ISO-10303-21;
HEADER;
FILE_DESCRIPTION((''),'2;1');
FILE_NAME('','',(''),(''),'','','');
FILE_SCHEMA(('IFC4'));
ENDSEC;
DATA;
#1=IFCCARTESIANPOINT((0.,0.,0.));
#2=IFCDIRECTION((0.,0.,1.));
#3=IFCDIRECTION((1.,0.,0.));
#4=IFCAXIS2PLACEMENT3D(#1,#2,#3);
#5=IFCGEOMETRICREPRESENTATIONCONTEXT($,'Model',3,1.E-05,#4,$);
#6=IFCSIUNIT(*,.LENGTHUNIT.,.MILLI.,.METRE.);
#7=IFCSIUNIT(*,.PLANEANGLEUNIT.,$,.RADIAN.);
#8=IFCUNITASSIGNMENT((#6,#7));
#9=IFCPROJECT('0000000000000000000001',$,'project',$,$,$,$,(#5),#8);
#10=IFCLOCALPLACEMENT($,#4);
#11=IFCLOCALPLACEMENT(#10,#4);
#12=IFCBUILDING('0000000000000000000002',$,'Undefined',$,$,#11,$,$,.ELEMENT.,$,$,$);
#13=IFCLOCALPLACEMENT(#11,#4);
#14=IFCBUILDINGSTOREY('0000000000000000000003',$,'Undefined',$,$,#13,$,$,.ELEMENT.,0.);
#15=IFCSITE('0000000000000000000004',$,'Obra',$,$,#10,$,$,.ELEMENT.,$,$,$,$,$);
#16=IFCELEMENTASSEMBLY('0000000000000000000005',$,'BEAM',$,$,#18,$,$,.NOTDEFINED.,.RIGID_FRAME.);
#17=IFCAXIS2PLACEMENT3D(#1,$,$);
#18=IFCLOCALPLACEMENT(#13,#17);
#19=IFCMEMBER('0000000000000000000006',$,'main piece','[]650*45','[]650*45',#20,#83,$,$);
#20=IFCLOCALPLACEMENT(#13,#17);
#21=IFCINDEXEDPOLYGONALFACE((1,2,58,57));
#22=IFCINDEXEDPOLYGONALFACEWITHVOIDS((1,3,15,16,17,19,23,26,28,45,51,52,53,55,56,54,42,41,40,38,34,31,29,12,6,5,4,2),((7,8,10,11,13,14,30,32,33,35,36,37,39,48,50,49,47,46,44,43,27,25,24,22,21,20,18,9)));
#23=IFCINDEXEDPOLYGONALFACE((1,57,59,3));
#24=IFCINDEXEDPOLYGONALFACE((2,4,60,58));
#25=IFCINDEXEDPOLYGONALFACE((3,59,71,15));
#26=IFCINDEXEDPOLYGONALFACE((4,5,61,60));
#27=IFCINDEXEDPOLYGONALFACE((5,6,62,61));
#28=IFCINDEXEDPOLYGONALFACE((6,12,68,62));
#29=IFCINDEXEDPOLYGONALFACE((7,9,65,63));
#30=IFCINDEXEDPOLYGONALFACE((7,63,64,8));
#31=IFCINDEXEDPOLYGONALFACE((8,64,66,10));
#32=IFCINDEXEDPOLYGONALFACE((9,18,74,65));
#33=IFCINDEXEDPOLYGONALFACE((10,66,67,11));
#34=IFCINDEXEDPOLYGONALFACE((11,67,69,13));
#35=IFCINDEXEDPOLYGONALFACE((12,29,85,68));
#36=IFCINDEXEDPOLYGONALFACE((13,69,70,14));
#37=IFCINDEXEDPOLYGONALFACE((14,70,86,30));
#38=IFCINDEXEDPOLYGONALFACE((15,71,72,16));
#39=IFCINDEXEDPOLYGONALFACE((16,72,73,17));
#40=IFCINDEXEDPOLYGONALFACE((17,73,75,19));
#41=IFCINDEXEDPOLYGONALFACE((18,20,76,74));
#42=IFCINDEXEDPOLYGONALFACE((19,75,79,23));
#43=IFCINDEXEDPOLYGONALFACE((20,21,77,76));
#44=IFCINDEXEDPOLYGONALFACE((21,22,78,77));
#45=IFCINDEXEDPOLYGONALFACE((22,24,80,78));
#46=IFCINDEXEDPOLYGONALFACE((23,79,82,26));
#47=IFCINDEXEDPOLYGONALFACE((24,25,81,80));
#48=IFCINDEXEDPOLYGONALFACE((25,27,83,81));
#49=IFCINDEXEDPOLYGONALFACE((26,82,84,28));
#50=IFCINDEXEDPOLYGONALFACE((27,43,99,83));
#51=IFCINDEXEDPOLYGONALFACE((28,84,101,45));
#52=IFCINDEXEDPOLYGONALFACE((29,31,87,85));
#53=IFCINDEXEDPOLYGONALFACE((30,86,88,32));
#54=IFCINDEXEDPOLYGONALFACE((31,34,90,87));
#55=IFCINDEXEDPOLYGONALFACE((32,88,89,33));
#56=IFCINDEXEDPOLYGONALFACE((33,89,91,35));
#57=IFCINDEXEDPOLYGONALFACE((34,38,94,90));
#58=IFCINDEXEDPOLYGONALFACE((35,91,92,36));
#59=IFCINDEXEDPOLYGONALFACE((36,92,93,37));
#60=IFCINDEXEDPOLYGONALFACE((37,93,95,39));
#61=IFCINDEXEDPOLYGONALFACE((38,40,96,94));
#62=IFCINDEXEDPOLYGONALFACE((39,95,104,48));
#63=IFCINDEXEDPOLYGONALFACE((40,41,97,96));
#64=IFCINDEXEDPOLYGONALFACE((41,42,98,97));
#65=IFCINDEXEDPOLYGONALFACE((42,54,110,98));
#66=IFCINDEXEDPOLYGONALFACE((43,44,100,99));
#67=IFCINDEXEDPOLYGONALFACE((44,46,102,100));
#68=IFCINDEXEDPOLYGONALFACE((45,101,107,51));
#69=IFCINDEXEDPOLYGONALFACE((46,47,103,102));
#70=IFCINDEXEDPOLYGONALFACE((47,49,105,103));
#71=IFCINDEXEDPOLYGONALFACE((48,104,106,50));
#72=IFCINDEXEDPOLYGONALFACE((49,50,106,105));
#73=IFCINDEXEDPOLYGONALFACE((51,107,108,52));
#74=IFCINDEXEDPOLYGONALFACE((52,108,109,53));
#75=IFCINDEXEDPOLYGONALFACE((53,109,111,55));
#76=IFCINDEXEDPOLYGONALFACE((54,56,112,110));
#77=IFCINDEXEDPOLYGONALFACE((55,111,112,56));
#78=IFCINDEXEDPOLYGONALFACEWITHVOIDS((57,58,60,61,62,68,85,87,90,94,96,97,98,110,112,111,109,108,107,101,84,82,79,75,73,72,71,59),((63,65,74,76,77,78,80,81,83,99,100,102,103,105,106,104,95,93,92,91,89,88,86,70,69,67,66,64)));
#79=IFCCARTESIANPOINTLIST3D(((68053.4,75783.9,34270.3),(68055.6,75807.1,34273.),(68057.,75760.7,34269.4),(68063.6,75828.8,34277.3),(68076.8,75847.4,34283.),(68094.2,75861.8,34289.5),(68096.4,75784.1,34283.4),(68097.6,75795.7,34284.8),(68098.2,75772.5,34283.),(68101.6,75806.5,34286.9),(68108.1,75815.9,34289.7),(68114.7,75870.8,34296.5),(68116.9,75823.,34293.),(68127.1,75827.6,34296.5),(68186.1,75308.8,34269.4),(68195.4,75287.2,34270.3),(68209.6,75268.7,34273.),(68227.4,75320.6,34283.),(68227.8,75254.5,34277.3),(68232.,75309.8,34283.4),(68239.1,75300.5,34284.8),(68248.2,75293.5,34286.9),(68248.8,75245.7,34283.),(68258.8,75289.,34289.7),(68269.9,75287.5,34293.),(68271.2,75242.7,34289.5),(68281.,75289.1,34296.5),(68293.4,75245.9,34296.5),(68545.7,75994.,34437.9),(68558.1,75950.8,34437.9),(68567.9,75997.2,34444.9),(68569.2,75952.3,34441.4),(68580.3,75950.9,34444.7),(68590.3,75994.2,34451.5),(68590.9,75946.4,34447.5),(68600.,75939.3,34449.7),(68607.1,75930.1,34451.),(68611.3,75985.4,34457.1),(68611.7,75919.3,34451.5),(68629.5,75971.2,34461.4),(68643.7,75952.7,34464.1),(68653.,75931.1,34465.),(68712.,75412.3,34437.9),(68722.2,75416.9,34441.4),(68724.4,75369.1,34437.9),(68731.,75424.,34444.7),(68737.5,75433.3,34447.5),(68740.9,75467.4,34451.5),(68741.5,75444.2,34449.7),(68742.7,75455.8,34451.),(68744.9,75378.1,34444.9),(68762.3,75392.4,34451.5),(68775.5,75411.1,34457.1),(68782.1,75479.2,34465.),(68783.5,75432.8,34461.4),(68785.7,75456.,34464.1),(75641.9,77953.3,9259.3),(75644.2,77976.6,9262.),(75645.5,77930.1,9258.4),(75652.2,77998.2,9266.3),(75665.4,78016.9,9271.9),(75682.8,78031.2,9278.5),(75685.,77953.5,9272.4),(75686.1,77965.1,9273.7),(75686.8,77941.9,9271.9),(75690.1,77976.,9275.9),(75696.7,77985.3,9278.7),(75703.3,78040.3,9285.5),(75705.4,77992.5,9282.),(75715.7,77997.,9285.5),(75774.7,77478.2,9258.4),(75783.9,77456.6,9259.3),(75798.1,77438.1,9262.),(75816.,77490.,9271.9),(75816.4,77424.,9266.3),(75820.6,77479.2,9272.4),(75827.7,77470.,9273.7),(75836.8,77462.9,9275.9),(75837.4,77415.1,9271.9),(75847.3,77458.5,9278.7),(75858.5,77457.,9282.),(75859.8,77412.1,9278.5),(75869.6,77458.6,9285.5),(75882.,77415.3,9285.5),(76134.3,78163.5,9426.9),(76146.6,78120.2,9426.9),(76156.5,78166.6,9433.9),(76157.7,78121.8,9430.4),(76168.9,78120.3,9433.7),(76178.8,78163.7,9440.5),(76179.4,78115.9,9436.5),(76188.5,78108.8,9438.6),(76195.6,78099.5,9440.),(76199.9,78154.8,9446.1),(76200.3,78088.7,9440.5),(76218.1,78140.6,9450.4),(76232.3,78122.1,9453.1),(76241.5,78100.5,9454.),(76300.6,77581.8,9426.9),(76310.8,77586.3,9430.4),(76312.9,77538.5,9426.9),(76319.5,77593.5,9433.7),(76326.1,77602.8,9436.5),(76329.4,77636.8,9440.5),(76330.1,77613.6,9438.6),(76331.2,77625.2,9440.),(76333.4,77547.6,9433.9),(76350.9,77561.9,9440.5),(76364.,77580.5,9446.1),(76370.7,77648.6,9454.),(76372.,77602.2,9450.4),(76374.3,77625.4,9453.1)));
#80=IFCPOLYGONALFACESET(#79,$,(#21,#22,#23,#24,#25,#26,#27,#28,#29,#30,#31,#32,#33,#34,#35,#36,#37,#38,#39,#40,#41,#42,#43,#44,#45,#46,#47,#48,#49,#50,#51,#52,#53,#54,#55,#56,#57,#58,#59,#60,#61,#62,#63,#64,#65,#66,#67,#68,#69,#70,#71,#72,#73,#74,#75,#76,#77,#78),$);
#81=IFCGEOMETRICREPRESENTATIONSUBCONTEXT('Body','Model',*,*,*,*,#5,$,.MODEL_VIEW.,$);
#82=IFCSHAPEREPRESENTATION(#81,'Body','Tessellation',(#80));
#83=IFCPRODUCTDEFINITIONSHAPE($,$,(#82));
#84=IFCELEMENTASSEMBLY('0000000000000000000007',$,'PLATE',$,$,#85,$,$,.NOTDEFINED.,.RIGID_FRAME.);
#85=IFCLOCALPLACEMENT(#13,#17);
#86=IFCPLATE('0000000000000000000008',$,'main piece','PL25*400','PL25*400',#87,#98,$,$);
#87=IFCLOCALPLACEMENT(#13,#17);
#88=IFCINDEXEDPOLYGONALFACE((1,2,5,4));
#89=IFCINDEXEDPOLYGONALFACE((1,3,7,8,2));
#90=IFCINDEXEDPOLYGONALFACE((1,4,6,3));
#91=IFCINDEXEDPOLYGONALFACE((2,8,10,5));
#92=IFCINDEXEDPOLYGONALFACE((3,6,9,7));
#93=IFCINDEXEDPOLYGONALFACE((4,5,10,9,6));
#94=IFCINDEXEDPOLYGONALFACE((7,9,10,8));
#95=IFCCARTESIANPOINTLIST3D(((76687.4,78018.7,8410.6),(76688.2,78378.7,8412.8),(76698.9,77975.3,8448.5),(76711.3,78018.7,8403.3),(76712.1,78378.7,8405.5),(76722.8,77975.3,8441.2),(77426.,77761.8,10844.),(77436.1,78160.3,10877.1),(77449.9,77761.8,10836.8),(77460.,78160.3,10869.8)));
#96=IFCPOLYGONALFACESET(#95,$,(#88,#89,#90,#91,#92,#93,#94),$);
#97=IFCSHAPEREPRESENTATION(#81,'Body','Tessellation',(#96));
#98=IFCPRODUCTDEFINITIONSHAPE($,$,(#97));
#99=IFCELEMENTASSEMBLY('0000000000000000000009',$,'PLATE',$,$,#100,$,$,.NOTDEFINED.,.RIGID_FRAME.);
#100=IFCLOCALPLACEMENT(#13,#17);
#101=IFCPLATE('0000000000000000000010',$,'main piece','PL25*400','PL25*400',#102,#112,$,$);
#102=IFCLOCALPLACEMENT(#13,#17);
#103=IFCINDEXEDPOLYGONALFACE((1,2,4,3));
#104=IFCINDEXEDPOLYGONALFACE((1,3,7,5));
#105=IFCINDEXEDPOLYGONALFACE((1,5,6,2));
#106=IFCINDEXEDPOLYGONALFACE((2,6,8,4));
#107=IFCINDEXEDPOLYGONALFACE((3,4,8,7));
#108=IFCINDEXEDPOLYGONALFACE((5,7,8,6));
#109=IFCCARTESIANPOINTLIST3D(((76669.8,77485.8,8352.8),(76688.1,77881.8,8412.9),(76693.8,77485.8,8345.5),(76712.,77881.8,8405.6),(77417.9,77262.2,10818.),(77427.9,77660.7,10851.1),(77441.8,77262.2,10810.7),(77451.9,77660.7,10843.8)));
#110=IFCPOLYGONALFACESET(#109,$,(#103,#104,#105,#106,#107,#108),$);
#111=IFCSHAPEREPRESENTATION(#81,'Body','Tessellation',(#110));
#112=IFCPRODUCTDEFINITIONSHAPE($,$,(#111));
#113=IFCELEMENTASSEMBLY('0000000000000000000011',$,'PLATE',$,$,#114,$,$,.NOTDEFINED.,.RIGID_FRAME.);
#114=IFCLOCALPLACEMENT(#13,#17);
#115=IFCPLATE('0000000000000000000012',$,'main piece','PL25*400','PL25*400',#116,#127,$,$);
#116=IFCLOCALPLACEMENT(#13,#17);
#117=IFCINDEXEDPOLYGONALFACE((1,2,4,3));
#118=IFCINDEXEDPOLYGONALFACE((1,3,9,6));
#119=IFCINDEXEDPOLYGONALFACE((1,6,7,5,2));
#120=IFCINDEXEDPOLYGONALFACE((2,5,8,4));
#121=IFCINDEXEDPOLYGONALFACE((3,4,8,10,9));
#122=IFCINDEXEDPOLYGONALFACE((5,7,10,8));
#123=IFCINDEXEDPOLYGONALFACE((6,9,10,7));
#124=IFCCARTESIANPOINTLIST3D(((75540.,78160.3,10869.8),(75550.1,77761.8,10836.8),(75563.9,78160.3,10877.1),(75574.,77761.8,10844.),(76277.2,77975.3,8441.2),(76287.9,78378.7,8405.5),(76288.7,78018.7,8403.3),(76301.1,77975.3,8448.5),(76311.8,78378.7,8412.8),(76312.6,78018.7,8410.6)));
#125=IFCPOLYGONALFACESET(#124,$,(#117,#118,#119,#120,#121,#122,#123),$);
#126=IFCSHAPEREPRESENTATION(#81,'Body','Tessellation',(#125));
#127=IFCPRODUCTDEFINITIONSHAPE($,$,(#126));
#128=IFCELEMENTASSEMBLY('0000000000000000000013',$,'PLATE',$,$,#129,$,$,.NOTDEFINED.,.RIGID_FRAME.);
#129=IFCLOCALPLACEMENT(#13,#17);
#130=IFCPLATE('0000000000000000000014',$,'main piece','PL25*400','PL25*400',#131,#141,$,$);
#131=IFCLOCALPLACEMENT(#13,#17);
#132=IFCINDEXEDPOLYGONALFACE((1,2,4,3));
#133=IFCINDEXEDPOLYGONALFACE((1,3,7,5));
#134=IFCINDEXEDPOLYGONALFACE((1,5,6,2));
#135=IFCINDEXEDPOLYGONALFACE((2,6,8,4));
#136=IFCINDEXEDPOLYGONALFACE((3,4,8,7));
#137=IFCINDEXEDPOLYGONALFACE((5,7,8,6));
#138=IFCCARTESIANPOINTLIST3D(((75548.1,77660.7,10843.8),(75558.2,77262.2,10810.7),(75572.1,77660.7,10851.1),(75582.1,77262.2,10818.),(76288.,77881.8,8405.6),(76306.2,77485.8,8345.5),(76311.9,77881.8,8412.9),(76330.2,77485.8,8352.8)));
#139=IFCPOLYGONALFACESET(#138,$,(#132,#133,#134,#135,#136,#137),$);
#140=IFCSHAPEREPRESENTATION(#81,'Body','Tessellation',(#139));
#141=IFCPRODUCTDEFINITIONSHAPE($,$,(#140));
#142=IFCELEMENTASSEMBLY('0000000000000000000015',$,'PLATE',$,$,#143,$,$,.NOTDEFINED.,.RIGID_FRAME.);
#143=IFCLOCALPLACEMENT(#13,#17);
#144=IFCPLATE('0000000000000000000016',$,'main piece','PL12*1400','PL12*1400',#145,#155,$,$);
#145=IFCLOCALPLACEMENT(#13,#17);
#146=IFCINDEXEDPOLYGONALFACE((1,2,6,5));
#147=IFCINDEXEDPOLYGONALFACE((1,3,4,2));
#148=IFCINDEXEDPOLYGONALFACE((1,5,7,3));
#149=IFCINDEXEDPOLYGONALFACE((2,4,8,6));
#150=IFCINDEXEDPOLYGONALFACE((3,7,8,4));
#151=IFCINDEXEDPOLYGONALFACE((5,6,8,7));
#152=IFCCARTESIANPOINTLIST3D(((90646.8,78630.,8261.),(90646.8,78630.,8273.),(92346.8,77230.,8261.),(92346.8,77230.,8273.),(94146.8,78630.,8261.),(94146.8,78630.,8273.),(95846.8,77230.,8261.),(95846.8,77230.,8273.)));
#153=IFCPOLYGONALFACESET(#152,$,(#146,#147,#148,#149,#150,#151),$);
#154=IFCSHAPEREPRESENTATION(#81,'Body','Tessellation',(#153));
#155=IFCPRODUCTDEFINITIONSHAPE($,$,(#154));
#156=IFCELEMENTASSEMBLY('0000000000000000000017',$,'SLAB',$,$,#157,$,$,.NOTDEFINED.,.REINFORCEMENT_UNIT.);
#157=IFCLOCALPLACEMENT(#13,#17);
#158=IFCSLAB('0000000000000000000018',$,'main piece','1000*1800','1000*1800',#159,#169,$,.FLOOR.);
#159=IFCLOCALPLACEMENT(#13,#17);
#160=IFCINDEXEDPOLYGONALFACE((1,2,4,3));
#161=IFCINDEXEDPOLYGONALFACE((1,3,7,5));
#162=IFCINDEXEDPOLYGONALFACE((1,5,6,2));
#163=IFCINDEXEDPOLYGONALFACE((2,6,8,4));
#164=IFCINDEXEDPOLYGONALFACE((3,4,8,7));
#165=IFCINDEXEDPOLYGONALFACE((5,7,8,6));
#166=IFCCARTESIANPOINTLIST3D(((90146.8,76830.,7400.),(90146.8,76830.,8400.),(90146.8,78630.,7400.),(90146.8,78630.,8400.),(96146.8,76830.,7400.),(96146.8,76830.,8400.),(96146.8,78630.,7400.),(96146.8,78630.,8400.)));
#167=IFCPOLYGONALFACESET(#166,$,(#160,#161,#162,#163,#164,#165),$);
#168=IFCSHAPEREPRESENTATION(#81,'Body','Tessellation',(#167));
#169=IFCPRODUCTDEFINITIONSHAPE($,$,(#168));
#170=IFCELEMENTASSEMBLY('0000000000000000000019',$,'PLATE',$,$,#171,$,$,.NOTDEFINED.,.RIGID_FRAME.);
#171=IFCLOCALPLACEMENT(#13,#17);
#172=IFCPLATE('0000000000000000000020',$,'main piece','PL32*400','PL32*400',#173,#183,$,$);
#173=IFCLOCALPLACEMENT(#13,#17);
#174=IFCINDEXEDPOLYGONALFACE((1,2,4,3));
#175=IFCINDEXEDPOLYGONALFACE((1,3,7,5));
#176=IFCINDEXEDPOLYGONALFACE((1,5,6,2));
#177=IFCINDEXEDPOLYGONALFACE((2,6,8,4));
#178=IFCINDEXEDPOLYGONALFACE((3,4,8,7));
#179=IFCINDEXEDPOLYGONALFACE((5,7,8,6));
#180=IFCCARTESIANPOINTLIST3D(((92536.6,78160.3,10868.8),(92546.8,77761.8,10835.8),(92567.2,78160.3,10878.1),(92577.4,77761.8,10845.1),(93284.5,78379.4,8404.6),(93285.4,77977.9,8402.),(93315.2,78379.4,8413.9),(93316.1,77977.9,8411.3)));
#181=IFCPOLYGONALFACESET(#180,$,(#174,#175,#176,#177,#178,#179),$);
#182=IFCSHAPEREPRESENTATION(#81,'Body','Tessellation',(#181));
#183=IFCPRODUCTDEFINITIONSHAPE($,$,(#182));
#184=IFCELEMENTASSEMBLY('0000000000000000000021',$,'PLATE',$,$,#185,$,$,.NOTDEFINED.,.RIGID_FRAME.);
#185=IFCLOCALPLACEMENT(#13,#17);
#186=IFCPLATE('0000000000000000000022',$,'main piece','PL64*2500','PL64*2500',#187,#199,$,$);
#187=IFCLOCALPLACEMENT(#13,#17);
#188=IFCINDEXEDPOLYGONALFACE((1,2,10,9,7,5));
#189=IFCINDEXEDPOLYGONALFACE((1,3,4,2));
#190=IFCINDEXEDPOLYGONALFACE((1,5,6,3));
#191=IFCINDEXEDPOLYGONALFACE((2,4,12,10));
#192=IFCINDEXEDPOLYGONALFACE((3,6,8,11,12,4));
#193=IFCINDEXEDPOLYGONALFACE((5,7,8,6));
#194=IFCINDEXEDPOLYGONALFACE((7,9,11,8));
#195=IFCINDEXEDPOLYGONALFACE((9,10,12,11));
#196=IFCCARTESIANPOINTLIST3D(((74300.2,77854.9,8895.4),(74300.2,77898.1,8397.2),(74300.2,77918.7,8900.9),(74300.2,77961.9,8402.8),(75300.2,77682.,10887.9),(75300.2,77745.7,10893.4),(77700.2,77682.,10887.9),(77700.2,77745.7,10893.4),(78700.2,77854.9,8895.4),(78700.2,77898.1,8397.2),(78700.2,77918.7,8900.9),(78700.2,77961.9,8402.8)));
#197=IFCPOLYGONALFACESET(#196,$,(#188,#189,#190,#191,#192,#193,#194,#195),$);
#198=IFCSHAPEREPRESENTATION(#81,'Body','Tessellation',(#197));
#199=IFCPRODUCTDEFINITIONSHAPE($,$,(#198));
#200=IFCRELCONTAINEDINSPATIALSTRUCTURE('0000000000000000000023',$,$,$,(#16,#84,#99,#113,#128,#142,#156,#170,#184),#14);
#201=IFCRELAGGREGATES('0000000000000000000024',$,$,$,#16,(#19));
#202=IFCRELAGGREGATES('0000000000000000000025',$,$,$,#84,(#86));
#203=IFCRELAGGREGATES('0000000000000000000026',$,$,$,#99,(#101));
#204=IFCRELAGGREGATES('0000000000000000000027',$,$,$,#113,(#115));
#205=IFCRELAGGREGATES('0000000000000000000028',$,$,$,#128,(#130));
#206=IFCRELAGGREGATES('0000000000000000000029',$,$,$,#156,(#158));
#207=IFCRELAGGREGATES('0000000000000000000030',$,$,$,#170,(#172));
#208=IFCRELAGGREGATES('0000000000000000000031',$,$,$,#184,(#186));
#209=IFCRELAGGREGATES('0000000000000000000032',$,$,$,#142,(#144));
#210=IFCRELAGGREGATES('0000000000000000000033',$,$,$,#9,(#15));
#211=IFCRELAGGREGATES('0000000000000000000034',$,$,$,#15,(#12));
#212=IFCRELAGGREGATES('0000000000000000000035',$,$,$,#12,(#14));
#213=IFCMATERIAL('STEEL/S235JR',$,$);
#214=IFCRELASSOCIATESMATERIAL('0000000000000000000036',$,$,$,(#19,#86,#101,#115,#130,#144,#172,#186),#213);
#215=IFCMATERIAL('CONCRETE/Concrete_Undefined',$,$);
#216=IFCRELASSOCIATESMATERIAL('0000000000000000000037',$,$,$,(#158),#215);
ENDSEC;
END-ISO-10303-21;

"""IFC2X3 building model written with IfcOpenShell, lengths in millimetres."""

from ifc_helpers import new_model, si_unit, frame, origin_with_axes, origin_2d_with_axis, place, context, subcontext, project, spatial, polyline, hollow_rectangle, outline, extrude, material, element, aggregate, save


model = new_model("IFC2X3")

# Units and contexts
model_context = context("Model", 3, precision=1e-05, world=origin_with_axes())
body_context = subcontext(model_context, "Body", "Model", "MODEL_VIEW")
ifc_project = project(units=[si_unit("LENGTHUNIT", "METRE", prefix="MILLI"), si_unit("PLANEANGLEUNIT", "RADIAN")], contexts=[model_context])

# Site, building, storey
site_placement = place(None, origin_with_axes())
site = spatial("IfcSite", under=ifc_project, at=site_placement, Name="Obra", CompositionType="ELEMENT")
building_placement = place(site_placement, origin_with_axes())
building = spatial("IfcBuilding", under=site, at=building_placement, Name="Undefined", CompositionType="ELEMENT")
storey_placement = place(building_placement, origin_with_axes())
storey = spatial("IfcBuildingStorey", under=building, at=storey_placement, Name="Undefined", CompositionType="ELEMENT", Elevation=0.0)

# Element assembly, member
ifc_material_1 = material(Name="STEEL/S235JR")
assembly_1_placement = place(storey_placement, origin_with_axes())
assembly_1 = element("IfcElementAssembly", 1, at=assembly_1_placement, inside=storey, Name="BEAM", AssemblyPlace="NOTDEFINED", PredefinedType="RIGID_FRAME")
member_1_placement = place(assembly_1_placement, frame((76008.1, 77789.4, 9356.2), z_axis=(0.916911, 0.262129, 0.300936), x_axis=(-0.289344, -0.082718, 0.953644)))
member_1 = element("IfcMember", 2, at=member_1_placement, material=ifc_material_1, Name="main piece", Description="[]650*45", ObjectType="[]650*45", context=body_context, shape_type="SweptSolid", body=[
    extrude(hollow_rectangle(XDim=650.0, YDim=650.0, WallThickness=45.0, InnerFilletRadius=45.0, OuterFilletRadius=90.0, at=origin_2d_with_axis()), frame((26226.8, 0.0, 0.0), z_axis=(-1.0, 0.0, 0.0), x_axis=(0.0, -1.0, 0.0)), (0.0, 0.0, 1.0), 26226.8),
])
aggregate(assembly_1, [member_1])

# Element assemblies, plates
assembly_2_placement = place(storey_placement, origin_with_axes())
assembly_2 = element("IfcElementAssembly", 3, at=assembly_2_placement, inside=storey, Name="PLATE", AssemblyPlace="NOTDEFINED", PredefinedType="RIGID_FRAME")
plate_1_placement = place(assembly_2_placement, frame((77437.9, 77761.8, 10840.4), z_axis=(-0.95689, 0.000272, 0.290451), x_axis=(0.025372, 0.996255, 0.082653)))
plate_1 = element("IfcPlate", 4, at=plate_1_placement, material=ifc_material_1, Name="main piece", Description="PL25*400", ObjectType="PL25*400", context=body_context, shape_type="SweptSolid", body=[
    extrude(outline(polyline([(0.0, 0.0), (400.0, 0.0), (394.9, 2584.6), (36.1, 2555.7), (-3.7, 2512.5), (0.0, 0.0)])), frame((0.0, 0.0, -12.5), z_axis=(0.0, 0.0, 1.0), x_axis=(1.0, 0.0, 0.0)), (0.0, 0.0, 1.0), 25.0),
])
aggregate(assembly_2, [plate_1])
assembly_3_placement = place(storey_placement, origin_with_axes())
assembly_3 = element("IfcElementAssembly", 5, at=assembly_3_placement, inside=storey, Name="PLATE", AssemblyPlace="NOTDEFINED", PredefinedType="RIGID_FRAME")
plate_2_placement = place(assembly_3_placement, frame((76700.1, 77881.8, 8409.3), z_axis=(-0.956915, 0.0, 0.290368), x_axis=(-0.045494, -0.98765, -0.149926)))
plate_2 = element("IfcPlate", 6, at=plate_2_placement, material=ifc_material_1, Name="main piece", Description="PL25*400", ObjectType="PL25*400", context=body_context, shape_type="SweptSolid", body=[
    extrude(outline(polyline([(0.0, 0.0), (401.0, 0.0), (218.2, 2579.4), (-180.8, 2551.1), (0.0, 0.0)])), frame((0.0, 0.0, -12.5), z_axis=(0.0, 0.0, 1.0), x_axis=(1.0, 0.0, 0.0)), (0.0, 0.0, 1.0), 25.0),
])
aggregate(assembly_3, [plate_2])
assembly_4_placement = place(storey_placement, origin_with_axes())
assembly_4 = element("IfcElementAssembly", 7, at=assembly_4_placement, inside=storey, Name="PLATE", AssemblyPlace="NOTDEFINED", PredefinedType="RIGID_FRAME")
plate_3_placement = place(assembly_4_placement, frame((75562.1, 77761.8, 10840.4), z_axis=(-0.95689, -0.000272, -0.290451), x_axis=(-0.025372, 0.996255, 0.082653)))
plate_3 = element("IfcPlate", 8, at=plate_3_placement, material=ifc_material_1, Name="main piece", Description="PL25*400", ObjectType="PL25*400", context=body_context, shape_type="SweptSolid", body=[
    extrude(outline(polyline([(0.0, 0.0), (400.0, 0.0), (394.9, 2584.6), (36.1, 2555.7), (-3.7, 2512.5), (0.0, 0.0)])), frame((0.0, 0.0, -12.5), z_axis=(0.0, 0.0, 1.0), x_axis=(1.0, 0.0, 0.0)), (0.0, 0.0, 1.0), 25.0),
])
aggregate(assembly_4, [plate_3])
assembly_5_placement = place(storey_placement, origin_with_axes())
assembly_5 = element("IfcElementAssembly", 9, at=assembly_5_placement, inside=storey, Name="PLATE", AssemblyPlace="NOTDEFINED", PredefinedType="RIGID_FRAME")
plate_4_placement = place(assembly_5_placement, frame((76299.9, 77881.8, 8409.3), z_axis=(-0.956915, 0.0, -0.290368), x_axis=(0.045494, -0.98765, -0.149926)))
plate_4 = element("IfcPlate", 10, at=plate_4_placement, material=ifc_material_1, Name="main piece", Description="PL25*400", ObjectType="PL25*400", context=body_context, shape_type="SweptSolid", body=[
    extrude(outline(polyline([(0.0, 0.0), (401.0, 0.0), (218.2, 2579.4), (-180.8, 2551.1), (0.0, 0.0)])), frame((0.0, 0.0, -12.5), z_axis=(0.0, 0.0, 1.0), x_axis=(1.0, 0.0, 0.0)), (0.0, 0.0, 1.0), 25.0),
])
aggregate(assembly_5, [plate_4])
assembly_6_placement = place(storey_placement, origin_with_axes())
assembly_6 = element("IfcElementAssembly", 11, at=assembly_6_placement, inside=storey, Name="PLATE", AssemblyPlace="NOTDEFINED", PredefinedType="RIGID_FRAME")
plate_5_placement = place(assembly_6_placement, frame((92346.8, 77230.0, 8267.0), z_axis=(0.0, 0.0, 1.0), x_axis=(1.0, 0.0, 0.0)))
plate_5 = element("IfcPlate", 12, at=plate_5_placement, material=ifc_material_1, Name="main piece", Description="PL12*1400", ObjectType="PL12*1400", context=body_context, shape_type="SweptSolid", body=[
    extrude(outline(polyline([(0.0, 0.0), (3500.0, 0.0), (1800.0, 1400.0), (-1700.0, 1400.0), (0.0, 0.0)])), frame((0.0, 0.0, -6.0), z_axis=(0.0, 0.0, 1.0), x_axis=(1.0, 0.0, 0.0)), (0.0, 0.0, 1.0), 12.0),
])

# Element assembly, slab
assembly_7_placement = place(storey_placement, origin_with_axes())
assembly_7 = element("IfcElementAssembly", 13, at=assembly_7_placement, inside=storey, Name="SLAB", AssemblyPlace="NOTDEFINED", PredefinedType="REINFORCEMENT_UNIT")
ifc_material_2 = material(Name="CONCRETE/Concrete_Undefined")
slab_placement = place(assembly_7_placement, frame((90146.8, 76830.0, 7900.0), z_axis=(0.0, 0.0, -1.0), x_axis=(0.0, 1.0, 0.0)))
slab = element("IfcSlab", 14, at=slab_placement, material=ifc_material_2, Name="main piece", Description="1000*1800", ObjectType="1000*1800", PredefinedType="FLOOR", context=body_context, shape_type="SweptSolid", body=[
    extrude(outline(polyline([(0.0, 0.0), (1800.0, 0.0), (1800.0, 6000.0), (0.0, 6000.0), (0.0, 0.0)])), frame((0.0, 0.0, -500.0), z_axis=(0.0, 0.0, 1.0), x_axis=(1.0, 0.0, 0.0)), (0.0, 0.0, 1.0), 1000.0),
])
aggregate(assembly_7, [slab])

# Element assemblies, plates
assembly_8_placement = place(storey_placement, origin_with_axes())
assembly_8 = element("IfcElementAssembly", 15, at=assembly_8_placement, inside=storey, Name="PLATE", AssemblyPlace="NOTDEFINED", PredefinedType="RIGID_FRAME")
plate_6_placement = place(assembly_8_placement, frame((92562.1, 77761.8, 10840.4), z_axis=(-0.95689, -0.000272, -0.290451), x_axis=(-0.025372, 0.996255, 0.082653)))
plate_6 = element("IfcPlate", 16, at=plate_6_placement, material=ifc_material_1, Name="main piece", Description="PL32*400", ObjectType="PL32*400", context=body_context, shape_type="SweptSolid", body=[
    extrude(outline(polyline([(0.0, 0.0), (400.0, 0.0), (395.7, 2584.5), (-4.6, 2552.6), (0.0, 0.0)])), frame((0.0, 0.0, -16.0), z_axis=(0.0, 0.0, 1.0), x_axis=(1.0, 0.0, 0.0)), (0.0, 0.0, 1.0), 32.0),
])
aggregate(assembly_8, [plate_6])
assembly_9_placement = place(storey_placement, origin_with_axes())
assembly_9 = element("IfcElementAssembly", 17, at=assembly_9_placement, inside=storey, Name="PLATE", AssemblyPlace="NOTDEFINED", PredefinedType="RIGID_FRAME")
plate_7_placement = place(assembly_9_placement, frame((74300.2, 77930.0, 8400.0), z_axis=(0.0, -0.996255, -0.08646), x_axis=(1.0, 0.0, 0.0)))
plate_7 = element("IfcPlate", 18, at=plate_7_placement, material=ifc_material_1, Name="main piece", Description="PL64*2500", ObjectType="PL64*2500", context=body_context, shape_type="SweptSolid", body=[
    extrude(outline(polyline([(0.0, 0.0), (4400.0, 0.0), (4400.0, 500.0), (3400.0, 2500.0), (1000.0, 2500.0), (0.0, 500.0), (0.0, 0.0)])), frame((0.0, 0.0, -32.0), z_axis=(0.0, 0.0, 1.0), x_axis=(1.0, 0.0, 0.0)), (0.0, 0.0, 1.0), 64.0),
])
aggregate(assembly_9, [plate_7])

aggregate(assembly_6, [plate_5])

save(model, "model.ifc")
